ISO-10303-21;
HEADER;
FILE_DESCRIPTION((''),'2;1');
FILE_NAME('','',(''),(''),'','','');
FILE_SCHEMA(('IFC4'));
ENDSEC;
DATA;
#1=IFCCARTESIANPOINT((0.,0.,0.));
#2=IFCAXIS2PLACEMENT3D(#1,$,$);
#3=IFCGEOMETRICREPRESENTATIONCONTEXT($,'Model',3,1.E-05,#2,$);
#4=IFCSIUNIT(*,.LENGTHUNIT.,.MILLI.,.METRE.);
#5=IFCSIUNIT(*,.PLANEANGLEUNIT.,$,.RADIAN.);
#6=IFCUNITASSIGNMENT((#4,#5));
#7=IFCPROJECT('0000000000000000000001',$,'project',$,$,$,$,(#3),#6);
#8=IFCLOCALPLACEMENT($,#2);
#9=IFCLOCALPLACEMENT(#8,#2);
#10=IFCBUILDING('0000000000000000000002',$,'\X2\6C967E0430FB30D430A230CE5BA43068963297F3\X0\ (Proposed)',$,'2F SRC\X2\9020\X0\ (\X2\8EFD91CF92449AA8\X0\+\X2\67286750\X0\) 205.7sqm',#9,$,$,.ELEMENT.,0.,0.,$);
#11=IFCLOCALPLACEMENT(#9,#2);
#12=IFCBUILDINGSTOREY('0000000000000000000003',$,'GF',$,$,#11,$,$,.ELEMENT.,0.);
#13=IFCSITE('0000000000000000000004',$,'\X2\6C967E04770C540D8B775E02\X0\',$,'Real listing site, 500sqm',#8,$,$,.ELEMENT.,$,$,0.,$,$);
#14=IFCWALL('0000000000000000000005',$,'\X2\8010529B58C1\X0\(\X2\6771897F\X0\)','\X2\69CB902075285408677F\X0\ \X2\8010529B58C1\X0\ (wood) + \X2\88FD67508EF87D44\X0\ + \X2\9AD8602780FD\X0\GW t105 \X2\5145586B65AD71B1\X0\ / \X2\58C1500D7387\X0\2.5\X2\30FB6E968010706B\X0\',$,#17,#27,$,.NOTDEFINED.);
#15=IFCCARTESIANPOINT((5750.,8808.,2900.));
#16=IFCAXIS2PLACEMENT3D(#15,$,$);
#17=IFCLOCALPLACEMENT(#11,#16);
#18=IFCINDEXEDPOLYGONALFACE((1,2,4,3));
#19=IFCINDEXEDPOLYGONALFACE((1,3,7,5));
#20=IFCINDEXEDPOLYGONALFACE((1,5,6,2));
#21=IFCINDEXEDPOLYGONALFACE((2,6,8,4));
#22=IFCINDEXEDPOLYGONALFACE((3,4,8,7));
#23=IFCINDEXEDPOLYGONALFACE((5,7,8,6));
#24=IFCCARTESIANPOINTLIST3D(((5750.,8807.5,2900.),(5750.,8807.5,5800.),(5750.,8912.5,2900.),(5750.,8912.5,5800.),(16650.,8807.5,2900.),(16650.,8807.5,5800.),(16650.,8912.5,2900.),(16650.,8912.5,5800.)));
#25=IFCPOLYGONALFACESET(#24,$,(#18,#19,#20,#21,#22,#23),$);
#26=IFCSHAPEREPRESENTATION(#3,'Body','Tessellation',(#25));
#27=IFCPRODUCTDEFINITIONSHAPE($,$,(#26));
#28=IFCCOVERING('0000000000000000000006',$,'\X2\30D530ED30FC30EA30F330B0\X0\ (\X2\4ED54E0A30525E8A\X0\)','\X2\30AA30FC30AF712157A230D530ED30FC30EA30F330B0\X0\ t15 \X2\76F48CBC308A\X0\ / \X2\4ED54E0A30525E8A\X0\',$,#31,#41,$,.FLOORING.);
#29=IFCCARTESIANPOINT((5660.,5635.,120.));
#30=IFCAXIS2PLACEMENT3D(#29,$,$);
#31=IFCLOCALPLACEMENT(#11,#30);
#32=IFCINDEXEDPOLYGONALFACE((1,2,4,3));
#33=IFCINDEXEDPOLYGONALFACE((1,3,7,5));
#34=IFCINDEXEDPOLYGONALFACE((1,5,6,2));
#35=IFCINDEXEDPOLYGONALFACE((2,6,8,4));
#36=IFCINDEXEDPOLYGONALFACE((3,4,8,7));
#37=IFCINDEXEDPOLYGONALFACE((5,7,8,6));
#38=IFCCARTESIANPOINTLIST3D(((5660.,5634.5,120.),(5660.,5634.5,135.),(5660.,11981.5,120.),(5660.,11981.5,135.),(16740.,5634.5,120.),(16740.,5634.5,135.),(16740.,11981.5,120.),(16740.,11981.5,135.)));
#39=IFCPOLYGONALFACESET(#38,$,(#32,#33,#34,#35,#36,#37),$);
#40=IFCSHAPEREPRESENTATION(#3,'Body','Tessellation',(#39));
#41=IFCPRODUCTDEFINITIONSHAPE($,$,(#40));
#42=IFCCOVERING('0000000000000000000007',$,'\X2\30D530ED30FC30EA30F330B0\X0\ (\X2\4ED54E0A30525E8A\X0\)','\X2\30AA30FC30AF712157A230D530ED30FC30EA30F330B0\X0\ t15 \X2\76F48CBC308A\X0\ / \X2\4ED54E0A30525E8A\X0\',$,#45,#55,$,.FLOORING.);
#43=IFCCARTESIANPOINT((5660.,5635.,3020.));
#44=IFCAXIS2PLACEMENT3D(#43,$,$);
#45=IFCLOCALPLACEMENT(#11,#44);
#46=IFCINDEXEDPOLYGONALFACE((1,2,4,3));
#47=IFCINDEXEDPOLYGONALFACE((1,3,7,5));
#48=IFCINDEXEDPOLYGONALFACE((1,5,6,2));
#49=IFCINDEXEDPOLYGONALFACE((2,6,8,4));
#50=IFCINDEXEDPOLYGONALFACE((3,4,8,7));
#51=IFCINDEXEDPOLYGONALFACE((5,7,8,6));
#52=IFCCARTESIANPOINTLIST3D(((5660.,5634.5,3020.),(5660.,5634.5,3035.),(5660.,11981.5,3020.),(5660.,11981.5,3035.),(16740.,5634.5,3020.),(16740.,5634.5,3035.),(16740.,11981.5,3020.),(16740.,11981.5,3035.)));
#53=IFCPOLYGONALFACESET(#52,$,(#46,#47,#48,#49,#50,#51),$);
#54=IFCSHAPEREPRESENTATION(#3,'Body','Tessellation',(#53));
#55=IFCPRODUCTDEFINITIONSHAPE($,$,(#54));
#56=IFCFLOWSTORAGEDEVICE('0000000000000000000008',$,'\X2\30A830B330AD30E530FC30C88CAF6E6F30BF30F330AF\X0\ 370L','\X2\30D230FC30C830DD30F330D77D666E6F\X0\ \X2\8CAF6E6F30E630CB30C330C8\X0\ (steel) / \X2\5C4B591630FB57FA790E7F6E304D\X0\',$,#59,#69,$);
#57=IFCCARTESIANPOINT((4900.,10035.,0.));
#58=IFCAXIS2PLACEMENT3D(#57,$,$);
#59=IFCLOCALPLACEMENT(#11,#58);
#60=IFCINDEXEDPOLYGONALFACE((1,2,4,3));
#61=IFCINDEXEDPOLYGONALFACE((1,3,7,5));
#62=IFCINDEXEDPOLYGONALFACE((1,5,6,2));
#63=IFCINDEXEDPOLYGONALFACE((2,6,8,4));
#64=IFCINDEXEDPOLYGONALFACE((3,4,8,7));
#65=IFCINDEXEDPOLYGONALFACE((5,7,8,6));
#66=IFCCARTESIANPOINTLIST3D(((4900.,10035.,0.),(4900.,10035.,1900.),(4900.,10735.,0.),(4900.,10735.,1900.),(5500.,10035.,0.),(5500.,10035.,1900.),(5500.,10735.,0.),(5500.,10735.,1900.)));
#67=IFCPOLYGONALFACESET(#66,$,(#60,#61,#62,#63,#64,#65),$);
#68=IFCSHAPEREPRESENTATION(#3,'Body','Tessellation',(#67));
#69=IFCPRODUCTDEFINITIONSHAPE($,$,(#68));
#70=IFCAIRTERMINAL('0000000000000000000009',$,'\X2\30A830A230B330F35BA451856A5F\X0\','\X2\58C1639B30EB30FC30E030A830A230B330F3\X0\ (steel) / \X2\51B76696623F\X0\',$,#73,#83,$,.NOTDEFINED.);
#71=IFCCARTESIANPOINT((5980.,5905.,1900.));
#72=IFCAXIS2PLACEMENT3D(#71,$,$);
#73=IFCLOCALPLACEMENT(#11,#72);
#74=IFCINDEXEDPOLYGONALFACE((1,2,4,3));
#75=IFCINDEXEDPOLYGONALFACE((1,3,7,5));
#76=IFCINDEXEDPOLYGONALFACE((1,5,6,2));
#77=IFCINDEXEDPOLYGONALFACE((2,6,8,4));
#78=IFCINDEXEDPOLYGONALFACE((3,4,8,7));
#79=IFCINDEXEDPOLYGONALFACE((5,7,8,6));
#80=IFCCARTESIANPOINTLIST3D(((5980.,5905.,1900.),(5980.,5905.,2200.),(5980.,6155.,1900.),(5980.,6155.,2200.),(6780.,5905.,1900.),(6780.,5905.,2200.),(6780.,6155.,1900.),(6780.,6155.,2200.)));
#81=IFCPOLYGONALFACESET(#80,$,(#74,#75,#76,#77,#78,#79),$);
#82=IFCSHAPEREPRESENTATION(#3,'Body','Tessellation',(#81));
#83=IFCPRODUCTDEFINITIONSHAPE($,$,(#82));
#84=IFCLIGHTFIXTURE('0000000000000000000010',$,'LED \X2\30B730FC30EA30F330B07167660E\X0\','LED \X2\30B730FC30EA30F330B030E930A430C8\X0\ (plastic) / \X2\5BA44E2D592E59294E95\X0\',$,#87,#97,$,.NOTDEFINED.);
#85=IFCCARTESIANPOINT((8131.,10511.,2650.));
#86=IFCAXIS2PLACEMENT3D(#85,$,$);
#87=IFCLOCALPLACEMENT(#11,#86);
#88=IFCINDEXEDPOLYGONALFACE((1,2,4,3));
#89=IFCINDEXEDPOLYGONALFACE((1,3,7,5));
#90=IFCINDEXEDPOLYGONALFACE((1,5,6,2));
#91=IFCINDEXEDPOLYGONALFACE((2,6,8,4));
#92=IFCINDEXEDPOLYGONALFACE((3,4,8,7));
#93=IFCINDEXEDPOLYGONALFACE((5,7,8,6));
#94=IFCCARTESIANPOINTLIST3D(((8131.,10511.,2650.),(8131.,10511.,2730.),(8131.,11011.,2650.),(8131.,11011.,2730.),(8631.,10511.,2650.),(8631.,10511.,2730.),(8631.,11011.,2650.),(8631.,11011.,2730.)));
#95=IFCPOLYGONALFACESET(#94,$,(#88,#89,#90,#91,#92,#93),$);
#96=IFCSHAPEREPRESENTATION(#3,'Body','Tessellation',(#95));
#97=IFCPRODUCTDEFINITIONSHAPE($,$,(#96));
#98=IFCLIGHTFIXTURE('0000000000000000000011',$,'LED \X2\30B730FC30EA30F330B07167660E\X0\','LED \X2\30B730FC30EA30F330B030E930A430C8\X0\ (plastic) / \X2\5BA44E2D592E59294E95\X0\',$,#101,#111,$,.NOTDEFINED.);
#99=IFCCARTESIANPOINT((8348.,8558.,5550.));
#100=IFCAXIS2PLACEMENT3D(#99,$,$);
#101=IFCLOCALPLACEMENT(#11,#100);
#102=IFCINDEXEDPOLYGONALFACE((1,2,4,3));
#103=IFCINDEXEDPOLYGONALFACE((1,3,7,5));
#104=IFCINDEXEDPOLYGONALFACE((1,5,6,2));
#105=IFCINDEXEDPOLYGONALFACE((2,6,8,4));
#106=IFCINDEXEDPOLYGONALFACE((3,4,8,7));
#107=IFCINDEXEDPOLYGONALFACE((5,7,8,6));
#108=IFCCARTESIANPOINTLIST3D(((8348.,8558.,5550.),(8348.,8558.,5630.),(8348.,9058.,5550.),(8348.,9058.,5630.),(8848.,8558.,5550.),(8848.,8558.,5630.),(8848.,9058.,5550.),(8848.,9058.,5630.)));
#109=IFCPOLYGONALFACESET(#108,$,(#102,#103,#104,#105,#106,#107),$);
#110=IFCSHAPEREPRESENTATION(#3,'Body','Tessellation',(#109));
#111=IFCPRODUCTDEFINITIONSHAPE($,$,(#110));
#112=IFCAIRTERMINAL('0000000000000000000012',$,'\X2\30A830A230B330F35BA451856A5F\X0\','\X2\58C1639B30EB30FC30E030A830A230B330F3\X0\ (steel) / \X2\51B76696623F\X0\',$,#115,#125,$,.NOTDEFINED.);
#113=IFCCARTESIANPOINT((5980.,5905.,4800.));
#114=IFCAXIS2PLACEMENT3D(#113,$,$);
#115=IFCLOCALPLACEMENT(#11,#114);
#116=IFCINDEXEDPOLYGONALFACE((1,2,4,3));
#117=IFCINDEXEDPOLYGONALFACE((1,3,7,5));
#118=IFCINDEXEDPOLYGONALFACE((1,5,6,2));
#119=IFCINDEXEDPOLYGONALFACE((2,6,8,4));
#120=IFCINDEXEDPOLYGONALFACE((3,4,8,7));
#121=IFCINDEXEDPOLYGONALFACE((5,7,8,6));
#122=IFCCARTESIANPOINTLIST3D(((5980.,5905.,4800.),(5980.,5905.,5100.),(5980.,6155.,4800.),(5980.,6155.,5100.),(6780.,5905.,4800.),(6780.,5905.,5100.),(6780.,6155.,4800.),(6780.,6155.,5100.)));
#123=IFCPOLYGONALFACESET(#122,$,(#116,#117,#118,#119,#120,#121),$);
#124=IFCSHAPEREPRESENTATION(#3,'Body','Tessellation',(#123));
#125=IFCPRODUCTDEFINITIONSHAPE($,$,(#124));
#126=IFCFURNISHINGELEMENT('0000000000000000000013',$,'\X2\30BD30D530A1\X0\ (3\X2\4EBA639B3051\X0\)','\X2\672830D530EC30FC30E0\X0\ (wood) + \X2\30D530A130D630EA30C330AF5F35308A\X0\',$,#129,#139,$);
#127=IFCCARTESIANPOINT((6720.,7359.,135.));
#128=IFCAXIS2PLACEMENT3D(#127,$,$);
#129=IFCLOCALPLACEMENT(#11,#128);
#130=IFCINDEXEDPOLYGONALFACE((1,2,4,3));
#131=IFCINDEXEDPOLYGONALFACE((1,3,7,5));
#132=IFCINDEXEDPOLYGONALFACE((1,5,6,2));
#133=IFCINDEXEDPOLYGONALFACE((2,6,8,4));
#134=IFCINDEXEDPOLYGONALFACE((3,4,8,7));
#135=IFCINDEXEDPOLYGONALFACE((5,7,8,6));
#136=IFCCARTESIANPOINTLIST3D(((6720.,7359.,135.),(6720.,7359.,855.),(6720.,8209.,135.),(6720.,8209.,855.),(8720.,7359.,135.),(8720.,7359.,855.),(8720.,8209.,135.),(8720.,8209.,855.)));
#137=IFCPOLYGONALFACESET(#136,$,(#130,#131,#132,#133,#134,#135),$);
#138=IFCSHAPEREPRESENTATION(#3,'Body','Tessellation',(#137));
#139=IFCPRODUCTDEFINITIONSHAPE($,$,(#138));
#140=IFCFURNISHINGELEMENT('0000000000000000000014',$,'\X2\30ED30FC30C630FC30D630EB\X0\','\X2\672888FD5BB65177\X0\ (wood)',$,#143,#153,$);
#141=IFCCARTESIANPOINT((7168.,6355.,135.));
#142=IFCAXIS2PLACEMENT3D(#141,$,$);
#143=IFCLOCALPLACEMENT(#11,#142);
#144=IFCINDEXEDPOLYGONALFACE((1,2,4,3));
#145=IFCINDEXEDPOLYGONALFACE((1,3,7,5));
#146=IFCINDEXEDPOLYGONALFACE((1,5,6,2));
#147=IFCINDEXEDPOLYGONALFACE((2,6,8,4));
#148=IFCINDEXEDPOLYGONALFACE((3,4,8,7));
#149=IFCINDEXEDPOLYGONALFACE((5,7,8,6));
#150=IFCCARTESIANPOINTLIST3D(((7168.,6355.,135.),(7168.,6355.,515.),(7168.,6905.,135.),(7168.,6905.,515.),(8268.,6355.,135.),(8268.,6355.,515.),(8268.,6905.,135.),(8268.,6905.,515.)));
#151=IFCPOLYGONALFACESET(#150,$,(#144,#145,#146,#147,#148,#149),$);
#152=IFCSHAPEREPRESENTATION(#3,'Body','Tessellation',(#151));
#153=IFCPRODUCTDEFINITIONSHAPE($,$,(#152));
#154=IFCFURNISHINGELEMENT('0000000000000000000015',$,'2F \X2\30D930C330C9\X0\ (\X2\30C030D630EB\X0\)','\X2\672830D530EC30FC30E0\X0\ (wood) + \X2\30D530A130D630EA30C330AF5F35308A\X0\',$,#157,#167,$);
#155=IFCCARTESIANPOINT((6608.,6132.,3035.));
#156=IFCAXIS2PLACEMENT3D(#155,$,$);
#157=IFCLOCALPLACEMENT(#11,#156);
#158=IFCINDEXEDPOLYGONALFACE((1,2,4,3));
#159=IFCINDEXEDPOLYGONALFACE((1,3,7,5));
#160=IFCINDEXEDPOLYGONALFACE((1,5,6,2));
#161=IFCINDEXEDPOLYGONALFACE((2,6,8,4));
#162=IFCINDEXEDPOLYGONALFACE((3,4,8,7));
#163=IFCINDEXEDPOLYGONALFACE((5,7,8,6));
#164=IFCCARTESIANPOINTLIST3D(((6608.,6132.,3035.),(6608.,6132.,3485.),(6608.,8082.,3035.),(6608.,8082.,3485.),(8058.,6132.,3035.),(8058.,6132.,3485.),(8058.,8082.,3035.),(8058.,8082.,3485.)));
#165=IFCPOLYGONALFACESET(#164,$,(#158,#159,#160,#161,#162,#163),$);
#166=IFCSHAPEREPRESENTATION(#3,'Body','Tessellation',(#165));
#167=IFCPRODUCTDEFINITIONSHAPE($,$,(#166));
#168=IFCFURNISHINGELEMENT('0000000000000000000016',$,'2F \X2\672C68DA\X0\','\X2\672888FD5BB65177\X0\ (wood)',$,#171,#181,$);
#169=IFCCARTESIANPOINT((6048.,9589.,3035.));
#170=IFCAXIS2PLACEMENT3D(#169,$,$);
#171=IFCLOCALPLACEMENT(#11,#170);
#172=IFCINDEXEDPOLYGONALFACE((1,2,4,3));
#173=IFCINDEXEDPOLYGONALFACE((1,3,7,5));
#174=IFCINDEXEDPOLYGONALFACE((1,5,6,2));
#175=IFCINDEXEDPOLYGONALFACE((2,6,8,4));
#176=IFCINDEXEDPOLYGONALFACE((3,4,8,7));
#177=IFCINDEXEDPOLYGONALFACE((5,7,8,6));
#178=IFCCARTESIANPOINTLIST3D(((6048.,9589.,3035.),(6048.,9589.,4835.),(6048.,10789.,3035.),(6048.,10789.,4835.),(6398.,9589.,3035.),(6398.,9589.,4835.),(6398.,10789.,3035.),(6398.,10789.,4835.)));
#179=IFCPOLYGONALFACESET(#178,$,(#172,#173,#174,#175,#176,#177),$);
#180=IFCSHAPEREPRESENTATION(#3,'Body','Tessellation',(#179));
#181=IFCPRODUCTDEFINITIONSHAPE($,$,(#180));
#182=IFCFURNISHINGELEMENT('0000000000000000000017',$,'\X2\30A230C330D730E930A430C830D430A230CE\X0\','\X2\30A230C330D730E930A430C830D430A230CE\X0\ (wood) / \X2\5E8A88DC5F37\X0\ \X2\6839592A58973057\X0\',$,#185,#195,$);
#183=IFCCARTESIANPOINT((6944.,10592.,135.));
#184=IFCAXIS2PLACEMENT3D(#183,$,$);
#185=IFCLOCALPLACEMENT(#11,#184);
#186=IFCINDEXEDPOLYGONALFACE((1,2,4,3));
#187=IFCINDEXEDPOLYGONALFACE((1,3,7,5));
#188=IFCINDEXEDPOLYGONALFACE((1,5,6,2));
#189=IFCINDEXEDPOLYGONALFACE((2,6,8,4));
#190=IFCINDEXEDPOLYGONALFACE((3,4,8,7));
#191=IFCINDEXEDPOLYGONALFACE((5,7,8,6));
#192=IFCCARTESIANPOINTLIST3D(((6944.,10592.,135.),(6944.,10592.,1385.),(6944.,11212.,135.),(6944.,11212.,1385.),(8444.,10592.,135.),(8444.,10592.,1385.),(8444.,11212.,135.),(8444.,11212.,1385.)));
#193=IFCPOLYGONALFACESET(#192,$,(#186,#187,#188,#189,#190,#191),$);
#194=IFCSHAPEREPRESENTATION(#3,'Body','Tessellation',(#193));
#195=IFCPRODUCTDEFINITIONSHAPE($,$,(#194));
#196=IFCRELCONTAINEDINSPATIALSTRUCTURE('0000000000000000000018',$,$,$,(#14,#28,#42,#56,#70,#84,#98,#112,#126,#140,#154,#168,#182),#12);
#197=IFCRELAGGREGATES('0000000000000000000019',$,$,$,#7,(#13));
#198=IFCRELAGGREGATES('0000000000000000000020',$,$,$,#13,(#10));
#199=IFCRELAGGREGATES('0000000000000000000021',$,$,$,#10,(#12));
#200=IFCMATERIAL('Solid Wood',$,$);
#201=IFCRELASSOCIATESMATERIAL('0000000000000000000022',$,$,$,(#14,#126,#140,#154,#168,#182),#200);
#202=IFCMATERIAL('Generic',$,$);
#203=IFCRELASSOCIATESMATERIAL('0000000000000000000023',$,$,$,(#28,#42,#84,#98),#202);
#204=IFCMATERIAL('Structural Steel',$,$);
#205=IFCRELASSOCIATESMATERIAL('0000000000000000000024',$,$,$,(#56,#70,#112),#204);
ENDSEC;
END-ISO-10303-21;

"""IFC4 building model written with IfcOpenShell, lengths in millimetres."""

from ifc_helpers import new_model, si_unit, frame, frame_2d, origin, place, context, project, spatial, rectangle, extrude, material, element, save


model = new_model("IFC4")

# Units and contexts
model_context = context("Model", 3, precision=1e-05, world=origin())
ifc_project = project(units=[si_unit("LENGTHUNIT", "METRE", prefix="MILLI"), si_unit("PLANEANGLEUNIT", "RADIAN")], contexts=[model_context])

# Site, building, storey
site_placement = place(None, origin())
site = spatial("IfcSite", under=ifc_project, at=site_placement, Name="沖縄県名護市", ObjectType="Real listing site, 500sqm", CompositionType="ELEMENT", RefElevation=0.0)
building_placement = place(site_placement, origin())
building = spatial("IfcBuilding", under=site, at=building_placement, Name="沖縄・ピアノ室と防音 (Proposed)", ObjectType="2F SRC造 (軽量鉄骨+木材) 205.7sqm", CompositionType="ELEMENT", ElevationOfRefHeight=0.0, ElevationOfTerrain=0.0)
storey_placement = place(building_placement, origin())
storey = spatial("IfcBuildingStorey", under=building, at=storey_placement, Name="GF", CompositionType="ELEMENT", Elevation=0.0)

# Shared definitions
ifc_material_1 = material(Name="Solid Wood")

# Wall
wall_1_placement = place(storey_placement, frame((5750.0, 8808.0, 2900.0)))
element("IfcWall", 1, at=wall_1_placement, inside=storey, material=ifc_material_1, Name="耐力壁(東西)", Description="構造用合板 耐力壁 (wood) + 製材軸組 + 高性能GW t105 充填断熱 / 壁倍率2.5・準耐火", PredefinedType="NOTDEFINED", context=model_context, shape_type="SweptSolid", body=[
    extrude(rectangle(XDim=10900.0, YDim=105.0, at=frame_2d((5450.0, 52.0))), frame((5750.0, 8808.0, 2900.0)), (0.0, 0.0, 1.0), 2900.0),
])

# Coverings
ifc_material_2 = material(Name="Generic")
covering_1_placement = place(storey_placement, frame((5660.0, 5635.0, 120.0)))
element("IfcCovering", 2, at=covering_1_placement, inside=storey, material=ifc_material_2, Name="フローリング (仕上げ床)", Description="オーク無垢フローリング t15 直貼り / 仕上げ床", PredefinedType="FLOORING", context=model_context, shape_type="SweptSolid", body=[
    extrude(rectangle(XDim=11080.0, YDim=6347.0, at=frame_2d((5540.0, 3173.0))), frame((5660.0, 5635.0, 120.0)), (0.0, 0.0, 1.0), 15.0),
])
covering_2_placement = place(storey_placement, frame((5660.0, 5635.0, 3020.0)))
element("IfcCovering", 3, at=covering_2_placement, inside=storey, material=ifc_material_2, Name="フローリング (仕上げ床)", Description="オーク無垢フローリング t15 直貼り / 仕上げ床", PredefinedType="FLOORING", context=model_context, shape_type="SweptSolid", body=[
    extrude(rectangle(XDim=11080.0, YDim=6347.0, at=frame_2d((5540.0, 3173.0))), frame((5660.0, 5635.0, 3020.0)), (0.0, 0.0, 1.0), 15.0),
])

# Flow storage device
ifc_material_3 = material(Name="Structural Steel")
flow_storage_device_placement = place(storey_placement, frame((4900.0, 10035.0, 0.0)))
element("IfcFlowStorageDevice", 4, at=flow_storage_device_placement, inside=storey, material=ifc_material_3, Name="エコキュート貯湯タンク 370L", Description="ヒートポンプ給湯 貯湯ユニット (steel) / 屋外・基礎置き", context=model_context, shape_type="SweptSolid", body=[
    extrude(rectangle(XDim=600.0, YDim=700.0, at=frame_2d((300.0, 350.0))), frame((4900.0, 10035.0, 0.0)), (0.0, 0.0, 1.0), 1900.0),
])

# Air terminal
air_terminal_1_placement = place(storey_placement, frame((5980.0, 5905.0, 1900.0)))
element("IfcAirTerminal", 5, at=air_terminal_1_placement, inside=storey, material=ifc_material_3, Name="エアコン室内機", Description="壁掛ルームエアコン (steel) / 冷暖房", PredefinedType="NOTDEFINED", context=model_context, shape_type="SweptSolid", body=[
    extrude(rectangle(XDim=800.0, YDim=250.0, at=frame_2d((400.0, 125.0))), frame((5980.0, 5905.0, 1900.0)), (0.0, 0.0, 1.0), 300.0),
])

# Light fixtures
light_fixture_1_placement = place(storey_placement, frame((8131.0, 10511.0, 2650.0)))
element("IfcLightFixture", 6, at=light_fixture_1_placement, inside=storey, material=ifc_material_2, Name="LED シーリング照明", Description="LED シーリングライト (plastic) / 室中央天井", PredefinedType="NOTDEFINED", context=model_context, shape_type="SweptSolid", body=[
    extrude(rectangle(XDim=500.0, YDim=500.0, at=frame_2d((250.0, 250.0))), frame((8131.0, 10511.0, 2650.0)), (0.0, 0.0, 1.0), 80.0),
])
light_fixture_2_placement = place(storey_placement, frame((8348.0, 8558.0, 5550.0)))
element("IfcLightFixture", 7, at=light_fixture_2_placement, inside=storey, material=ifc_material_2, Name="LED シーリング照明", Description="LED シーリングライト (plastic) / 室中央天井", PredefinedType="NOTDEFINED", context=model_context, shape_type="SweptSolid", body=[
    extrude(rectangle(XDim=500.0, YDim=500.0, at=frame_2d((250.0, 250.0))), frame((8348.0, 8558.0, 5550.0)), (0.0, 0.0, 1.0), 80.0),
])

# Air terminal
air_terminal_2_placement = place(storey_placement, frame((5980.0, 5905.0, 4800.0)))
element("IfcAirTerminal", 8, at=air_terminal_2_placement, inside=storey, material=ifc_material_3, Name="エアコン室内機", Description="壁掛ルームエアコン (steel) / 冷暖房", PredefinedType="NOTDEFINED", context=model_context, shape_type="SweptSolid", body=[
    extrude(rectangle(XDim=800.0, YDim=250.0, at=frame_2d((400.0, 125.0))), frame((5980.0, 5905.0, 4800.0)), (0.0, 0.0, 1.0), 300.0),
])

# Furnishing elements
furnishing_1_placement = place(storey_placement, frame((6720.0, 7359.0, 135.0)))
element("IfcFurnishingElement", 9, at=furnishing_1_placement, inside=storey, material=ifc_material_1, Name="ソファ (3人掛け)", Description="木フレーム (wood) + ファブリック張り", context=model_context, shape_type="SweptSolid", body=[
    extrude(rectangle(XDim=2000.0, YDim=850.0, at=frame_2d((1000.0, 425.0))), frame((6720.0, 7359.0, 135.0)), (0.0, 0.0, 1.0), 720.0),
])
furnishing_2_placement = place(storey_placement, frame((7168.0, 6355.0, 135.0)))
element("IfcFurnishingElement", 10, at=furnishing_2_placement, inside=storey, material=ifc_material_1, Name="ローテーブル", Description="木製家具 (wood)", context=model_context, shape_type="SweptSolid", body=[
    extrude(rectangle(XDim=1100.0, YDim=550.0, at=frame_2d((550.0, 275.0))), frame((7168.0, 6355.0, 135.0)), (0.0, 0.0, 1.0), 380.0),
])
furnishing_3_placement = place(storey_placement, frame((6608.0, 6132.0, 3035.0)))
element("IfcFurnishingElement", 11, at=furnishing_3_placement, inside=storey, material=ifc_material_1, Name="2F ベッド (ダブル)", Description="木フレーム (wood) + ファブリック張り", context=model_context, shape_type="SweptSolid", body=[
    extrude(rectangle(XDim=1450.0, YDim=1950.0, at=frame_2d((725.0, 975.0))), frame((6608.0, 6132.0, 3035.0)), (0.0, 0.0, 1.0), 450.0),
])
furnishing_4_placement = place(storey_placement, frame((6048.0, 9589.0, 3035.0)))
element("IfcFurnishingElement", 12, at=furnishing_4_placement, inside=storey, material=ifc_material_1, Name="2F 本棚", Description="木製家具 (wood)", context=model_context, shape_type="SweptSolid", body=[
    extrude(rectangle(XDim=350.0, YDim=1200.0, at=frame_2d((175.0, 600.0))), frame((6048.0, 9589.0, 3035.0)), (0.0, 0.0, 1.0), 1800.0),
])
furnishing_5_placement = place(storey_placement, frame((6944.0, 10592.0, 135.0)))
element("IfcFurnishingElement", 13, at=furnishing_5_placement, inside=storey, material=ifc_material_1, Name="アップライトピアノ", Description="アップライトピアノ (wood) / 床補強 根太増し", context=model_context, shape_type="SweptSolid", body=[
    extrude(rectangle(XDim=1500.0, YDim=620.0, at=frame_2d((750.0, 310.0))), frame((6944.0, 10592.0, 135.0)), (0.0, 0.0, 1.0), 1250.0),
])

save(model, "model.ifc")
